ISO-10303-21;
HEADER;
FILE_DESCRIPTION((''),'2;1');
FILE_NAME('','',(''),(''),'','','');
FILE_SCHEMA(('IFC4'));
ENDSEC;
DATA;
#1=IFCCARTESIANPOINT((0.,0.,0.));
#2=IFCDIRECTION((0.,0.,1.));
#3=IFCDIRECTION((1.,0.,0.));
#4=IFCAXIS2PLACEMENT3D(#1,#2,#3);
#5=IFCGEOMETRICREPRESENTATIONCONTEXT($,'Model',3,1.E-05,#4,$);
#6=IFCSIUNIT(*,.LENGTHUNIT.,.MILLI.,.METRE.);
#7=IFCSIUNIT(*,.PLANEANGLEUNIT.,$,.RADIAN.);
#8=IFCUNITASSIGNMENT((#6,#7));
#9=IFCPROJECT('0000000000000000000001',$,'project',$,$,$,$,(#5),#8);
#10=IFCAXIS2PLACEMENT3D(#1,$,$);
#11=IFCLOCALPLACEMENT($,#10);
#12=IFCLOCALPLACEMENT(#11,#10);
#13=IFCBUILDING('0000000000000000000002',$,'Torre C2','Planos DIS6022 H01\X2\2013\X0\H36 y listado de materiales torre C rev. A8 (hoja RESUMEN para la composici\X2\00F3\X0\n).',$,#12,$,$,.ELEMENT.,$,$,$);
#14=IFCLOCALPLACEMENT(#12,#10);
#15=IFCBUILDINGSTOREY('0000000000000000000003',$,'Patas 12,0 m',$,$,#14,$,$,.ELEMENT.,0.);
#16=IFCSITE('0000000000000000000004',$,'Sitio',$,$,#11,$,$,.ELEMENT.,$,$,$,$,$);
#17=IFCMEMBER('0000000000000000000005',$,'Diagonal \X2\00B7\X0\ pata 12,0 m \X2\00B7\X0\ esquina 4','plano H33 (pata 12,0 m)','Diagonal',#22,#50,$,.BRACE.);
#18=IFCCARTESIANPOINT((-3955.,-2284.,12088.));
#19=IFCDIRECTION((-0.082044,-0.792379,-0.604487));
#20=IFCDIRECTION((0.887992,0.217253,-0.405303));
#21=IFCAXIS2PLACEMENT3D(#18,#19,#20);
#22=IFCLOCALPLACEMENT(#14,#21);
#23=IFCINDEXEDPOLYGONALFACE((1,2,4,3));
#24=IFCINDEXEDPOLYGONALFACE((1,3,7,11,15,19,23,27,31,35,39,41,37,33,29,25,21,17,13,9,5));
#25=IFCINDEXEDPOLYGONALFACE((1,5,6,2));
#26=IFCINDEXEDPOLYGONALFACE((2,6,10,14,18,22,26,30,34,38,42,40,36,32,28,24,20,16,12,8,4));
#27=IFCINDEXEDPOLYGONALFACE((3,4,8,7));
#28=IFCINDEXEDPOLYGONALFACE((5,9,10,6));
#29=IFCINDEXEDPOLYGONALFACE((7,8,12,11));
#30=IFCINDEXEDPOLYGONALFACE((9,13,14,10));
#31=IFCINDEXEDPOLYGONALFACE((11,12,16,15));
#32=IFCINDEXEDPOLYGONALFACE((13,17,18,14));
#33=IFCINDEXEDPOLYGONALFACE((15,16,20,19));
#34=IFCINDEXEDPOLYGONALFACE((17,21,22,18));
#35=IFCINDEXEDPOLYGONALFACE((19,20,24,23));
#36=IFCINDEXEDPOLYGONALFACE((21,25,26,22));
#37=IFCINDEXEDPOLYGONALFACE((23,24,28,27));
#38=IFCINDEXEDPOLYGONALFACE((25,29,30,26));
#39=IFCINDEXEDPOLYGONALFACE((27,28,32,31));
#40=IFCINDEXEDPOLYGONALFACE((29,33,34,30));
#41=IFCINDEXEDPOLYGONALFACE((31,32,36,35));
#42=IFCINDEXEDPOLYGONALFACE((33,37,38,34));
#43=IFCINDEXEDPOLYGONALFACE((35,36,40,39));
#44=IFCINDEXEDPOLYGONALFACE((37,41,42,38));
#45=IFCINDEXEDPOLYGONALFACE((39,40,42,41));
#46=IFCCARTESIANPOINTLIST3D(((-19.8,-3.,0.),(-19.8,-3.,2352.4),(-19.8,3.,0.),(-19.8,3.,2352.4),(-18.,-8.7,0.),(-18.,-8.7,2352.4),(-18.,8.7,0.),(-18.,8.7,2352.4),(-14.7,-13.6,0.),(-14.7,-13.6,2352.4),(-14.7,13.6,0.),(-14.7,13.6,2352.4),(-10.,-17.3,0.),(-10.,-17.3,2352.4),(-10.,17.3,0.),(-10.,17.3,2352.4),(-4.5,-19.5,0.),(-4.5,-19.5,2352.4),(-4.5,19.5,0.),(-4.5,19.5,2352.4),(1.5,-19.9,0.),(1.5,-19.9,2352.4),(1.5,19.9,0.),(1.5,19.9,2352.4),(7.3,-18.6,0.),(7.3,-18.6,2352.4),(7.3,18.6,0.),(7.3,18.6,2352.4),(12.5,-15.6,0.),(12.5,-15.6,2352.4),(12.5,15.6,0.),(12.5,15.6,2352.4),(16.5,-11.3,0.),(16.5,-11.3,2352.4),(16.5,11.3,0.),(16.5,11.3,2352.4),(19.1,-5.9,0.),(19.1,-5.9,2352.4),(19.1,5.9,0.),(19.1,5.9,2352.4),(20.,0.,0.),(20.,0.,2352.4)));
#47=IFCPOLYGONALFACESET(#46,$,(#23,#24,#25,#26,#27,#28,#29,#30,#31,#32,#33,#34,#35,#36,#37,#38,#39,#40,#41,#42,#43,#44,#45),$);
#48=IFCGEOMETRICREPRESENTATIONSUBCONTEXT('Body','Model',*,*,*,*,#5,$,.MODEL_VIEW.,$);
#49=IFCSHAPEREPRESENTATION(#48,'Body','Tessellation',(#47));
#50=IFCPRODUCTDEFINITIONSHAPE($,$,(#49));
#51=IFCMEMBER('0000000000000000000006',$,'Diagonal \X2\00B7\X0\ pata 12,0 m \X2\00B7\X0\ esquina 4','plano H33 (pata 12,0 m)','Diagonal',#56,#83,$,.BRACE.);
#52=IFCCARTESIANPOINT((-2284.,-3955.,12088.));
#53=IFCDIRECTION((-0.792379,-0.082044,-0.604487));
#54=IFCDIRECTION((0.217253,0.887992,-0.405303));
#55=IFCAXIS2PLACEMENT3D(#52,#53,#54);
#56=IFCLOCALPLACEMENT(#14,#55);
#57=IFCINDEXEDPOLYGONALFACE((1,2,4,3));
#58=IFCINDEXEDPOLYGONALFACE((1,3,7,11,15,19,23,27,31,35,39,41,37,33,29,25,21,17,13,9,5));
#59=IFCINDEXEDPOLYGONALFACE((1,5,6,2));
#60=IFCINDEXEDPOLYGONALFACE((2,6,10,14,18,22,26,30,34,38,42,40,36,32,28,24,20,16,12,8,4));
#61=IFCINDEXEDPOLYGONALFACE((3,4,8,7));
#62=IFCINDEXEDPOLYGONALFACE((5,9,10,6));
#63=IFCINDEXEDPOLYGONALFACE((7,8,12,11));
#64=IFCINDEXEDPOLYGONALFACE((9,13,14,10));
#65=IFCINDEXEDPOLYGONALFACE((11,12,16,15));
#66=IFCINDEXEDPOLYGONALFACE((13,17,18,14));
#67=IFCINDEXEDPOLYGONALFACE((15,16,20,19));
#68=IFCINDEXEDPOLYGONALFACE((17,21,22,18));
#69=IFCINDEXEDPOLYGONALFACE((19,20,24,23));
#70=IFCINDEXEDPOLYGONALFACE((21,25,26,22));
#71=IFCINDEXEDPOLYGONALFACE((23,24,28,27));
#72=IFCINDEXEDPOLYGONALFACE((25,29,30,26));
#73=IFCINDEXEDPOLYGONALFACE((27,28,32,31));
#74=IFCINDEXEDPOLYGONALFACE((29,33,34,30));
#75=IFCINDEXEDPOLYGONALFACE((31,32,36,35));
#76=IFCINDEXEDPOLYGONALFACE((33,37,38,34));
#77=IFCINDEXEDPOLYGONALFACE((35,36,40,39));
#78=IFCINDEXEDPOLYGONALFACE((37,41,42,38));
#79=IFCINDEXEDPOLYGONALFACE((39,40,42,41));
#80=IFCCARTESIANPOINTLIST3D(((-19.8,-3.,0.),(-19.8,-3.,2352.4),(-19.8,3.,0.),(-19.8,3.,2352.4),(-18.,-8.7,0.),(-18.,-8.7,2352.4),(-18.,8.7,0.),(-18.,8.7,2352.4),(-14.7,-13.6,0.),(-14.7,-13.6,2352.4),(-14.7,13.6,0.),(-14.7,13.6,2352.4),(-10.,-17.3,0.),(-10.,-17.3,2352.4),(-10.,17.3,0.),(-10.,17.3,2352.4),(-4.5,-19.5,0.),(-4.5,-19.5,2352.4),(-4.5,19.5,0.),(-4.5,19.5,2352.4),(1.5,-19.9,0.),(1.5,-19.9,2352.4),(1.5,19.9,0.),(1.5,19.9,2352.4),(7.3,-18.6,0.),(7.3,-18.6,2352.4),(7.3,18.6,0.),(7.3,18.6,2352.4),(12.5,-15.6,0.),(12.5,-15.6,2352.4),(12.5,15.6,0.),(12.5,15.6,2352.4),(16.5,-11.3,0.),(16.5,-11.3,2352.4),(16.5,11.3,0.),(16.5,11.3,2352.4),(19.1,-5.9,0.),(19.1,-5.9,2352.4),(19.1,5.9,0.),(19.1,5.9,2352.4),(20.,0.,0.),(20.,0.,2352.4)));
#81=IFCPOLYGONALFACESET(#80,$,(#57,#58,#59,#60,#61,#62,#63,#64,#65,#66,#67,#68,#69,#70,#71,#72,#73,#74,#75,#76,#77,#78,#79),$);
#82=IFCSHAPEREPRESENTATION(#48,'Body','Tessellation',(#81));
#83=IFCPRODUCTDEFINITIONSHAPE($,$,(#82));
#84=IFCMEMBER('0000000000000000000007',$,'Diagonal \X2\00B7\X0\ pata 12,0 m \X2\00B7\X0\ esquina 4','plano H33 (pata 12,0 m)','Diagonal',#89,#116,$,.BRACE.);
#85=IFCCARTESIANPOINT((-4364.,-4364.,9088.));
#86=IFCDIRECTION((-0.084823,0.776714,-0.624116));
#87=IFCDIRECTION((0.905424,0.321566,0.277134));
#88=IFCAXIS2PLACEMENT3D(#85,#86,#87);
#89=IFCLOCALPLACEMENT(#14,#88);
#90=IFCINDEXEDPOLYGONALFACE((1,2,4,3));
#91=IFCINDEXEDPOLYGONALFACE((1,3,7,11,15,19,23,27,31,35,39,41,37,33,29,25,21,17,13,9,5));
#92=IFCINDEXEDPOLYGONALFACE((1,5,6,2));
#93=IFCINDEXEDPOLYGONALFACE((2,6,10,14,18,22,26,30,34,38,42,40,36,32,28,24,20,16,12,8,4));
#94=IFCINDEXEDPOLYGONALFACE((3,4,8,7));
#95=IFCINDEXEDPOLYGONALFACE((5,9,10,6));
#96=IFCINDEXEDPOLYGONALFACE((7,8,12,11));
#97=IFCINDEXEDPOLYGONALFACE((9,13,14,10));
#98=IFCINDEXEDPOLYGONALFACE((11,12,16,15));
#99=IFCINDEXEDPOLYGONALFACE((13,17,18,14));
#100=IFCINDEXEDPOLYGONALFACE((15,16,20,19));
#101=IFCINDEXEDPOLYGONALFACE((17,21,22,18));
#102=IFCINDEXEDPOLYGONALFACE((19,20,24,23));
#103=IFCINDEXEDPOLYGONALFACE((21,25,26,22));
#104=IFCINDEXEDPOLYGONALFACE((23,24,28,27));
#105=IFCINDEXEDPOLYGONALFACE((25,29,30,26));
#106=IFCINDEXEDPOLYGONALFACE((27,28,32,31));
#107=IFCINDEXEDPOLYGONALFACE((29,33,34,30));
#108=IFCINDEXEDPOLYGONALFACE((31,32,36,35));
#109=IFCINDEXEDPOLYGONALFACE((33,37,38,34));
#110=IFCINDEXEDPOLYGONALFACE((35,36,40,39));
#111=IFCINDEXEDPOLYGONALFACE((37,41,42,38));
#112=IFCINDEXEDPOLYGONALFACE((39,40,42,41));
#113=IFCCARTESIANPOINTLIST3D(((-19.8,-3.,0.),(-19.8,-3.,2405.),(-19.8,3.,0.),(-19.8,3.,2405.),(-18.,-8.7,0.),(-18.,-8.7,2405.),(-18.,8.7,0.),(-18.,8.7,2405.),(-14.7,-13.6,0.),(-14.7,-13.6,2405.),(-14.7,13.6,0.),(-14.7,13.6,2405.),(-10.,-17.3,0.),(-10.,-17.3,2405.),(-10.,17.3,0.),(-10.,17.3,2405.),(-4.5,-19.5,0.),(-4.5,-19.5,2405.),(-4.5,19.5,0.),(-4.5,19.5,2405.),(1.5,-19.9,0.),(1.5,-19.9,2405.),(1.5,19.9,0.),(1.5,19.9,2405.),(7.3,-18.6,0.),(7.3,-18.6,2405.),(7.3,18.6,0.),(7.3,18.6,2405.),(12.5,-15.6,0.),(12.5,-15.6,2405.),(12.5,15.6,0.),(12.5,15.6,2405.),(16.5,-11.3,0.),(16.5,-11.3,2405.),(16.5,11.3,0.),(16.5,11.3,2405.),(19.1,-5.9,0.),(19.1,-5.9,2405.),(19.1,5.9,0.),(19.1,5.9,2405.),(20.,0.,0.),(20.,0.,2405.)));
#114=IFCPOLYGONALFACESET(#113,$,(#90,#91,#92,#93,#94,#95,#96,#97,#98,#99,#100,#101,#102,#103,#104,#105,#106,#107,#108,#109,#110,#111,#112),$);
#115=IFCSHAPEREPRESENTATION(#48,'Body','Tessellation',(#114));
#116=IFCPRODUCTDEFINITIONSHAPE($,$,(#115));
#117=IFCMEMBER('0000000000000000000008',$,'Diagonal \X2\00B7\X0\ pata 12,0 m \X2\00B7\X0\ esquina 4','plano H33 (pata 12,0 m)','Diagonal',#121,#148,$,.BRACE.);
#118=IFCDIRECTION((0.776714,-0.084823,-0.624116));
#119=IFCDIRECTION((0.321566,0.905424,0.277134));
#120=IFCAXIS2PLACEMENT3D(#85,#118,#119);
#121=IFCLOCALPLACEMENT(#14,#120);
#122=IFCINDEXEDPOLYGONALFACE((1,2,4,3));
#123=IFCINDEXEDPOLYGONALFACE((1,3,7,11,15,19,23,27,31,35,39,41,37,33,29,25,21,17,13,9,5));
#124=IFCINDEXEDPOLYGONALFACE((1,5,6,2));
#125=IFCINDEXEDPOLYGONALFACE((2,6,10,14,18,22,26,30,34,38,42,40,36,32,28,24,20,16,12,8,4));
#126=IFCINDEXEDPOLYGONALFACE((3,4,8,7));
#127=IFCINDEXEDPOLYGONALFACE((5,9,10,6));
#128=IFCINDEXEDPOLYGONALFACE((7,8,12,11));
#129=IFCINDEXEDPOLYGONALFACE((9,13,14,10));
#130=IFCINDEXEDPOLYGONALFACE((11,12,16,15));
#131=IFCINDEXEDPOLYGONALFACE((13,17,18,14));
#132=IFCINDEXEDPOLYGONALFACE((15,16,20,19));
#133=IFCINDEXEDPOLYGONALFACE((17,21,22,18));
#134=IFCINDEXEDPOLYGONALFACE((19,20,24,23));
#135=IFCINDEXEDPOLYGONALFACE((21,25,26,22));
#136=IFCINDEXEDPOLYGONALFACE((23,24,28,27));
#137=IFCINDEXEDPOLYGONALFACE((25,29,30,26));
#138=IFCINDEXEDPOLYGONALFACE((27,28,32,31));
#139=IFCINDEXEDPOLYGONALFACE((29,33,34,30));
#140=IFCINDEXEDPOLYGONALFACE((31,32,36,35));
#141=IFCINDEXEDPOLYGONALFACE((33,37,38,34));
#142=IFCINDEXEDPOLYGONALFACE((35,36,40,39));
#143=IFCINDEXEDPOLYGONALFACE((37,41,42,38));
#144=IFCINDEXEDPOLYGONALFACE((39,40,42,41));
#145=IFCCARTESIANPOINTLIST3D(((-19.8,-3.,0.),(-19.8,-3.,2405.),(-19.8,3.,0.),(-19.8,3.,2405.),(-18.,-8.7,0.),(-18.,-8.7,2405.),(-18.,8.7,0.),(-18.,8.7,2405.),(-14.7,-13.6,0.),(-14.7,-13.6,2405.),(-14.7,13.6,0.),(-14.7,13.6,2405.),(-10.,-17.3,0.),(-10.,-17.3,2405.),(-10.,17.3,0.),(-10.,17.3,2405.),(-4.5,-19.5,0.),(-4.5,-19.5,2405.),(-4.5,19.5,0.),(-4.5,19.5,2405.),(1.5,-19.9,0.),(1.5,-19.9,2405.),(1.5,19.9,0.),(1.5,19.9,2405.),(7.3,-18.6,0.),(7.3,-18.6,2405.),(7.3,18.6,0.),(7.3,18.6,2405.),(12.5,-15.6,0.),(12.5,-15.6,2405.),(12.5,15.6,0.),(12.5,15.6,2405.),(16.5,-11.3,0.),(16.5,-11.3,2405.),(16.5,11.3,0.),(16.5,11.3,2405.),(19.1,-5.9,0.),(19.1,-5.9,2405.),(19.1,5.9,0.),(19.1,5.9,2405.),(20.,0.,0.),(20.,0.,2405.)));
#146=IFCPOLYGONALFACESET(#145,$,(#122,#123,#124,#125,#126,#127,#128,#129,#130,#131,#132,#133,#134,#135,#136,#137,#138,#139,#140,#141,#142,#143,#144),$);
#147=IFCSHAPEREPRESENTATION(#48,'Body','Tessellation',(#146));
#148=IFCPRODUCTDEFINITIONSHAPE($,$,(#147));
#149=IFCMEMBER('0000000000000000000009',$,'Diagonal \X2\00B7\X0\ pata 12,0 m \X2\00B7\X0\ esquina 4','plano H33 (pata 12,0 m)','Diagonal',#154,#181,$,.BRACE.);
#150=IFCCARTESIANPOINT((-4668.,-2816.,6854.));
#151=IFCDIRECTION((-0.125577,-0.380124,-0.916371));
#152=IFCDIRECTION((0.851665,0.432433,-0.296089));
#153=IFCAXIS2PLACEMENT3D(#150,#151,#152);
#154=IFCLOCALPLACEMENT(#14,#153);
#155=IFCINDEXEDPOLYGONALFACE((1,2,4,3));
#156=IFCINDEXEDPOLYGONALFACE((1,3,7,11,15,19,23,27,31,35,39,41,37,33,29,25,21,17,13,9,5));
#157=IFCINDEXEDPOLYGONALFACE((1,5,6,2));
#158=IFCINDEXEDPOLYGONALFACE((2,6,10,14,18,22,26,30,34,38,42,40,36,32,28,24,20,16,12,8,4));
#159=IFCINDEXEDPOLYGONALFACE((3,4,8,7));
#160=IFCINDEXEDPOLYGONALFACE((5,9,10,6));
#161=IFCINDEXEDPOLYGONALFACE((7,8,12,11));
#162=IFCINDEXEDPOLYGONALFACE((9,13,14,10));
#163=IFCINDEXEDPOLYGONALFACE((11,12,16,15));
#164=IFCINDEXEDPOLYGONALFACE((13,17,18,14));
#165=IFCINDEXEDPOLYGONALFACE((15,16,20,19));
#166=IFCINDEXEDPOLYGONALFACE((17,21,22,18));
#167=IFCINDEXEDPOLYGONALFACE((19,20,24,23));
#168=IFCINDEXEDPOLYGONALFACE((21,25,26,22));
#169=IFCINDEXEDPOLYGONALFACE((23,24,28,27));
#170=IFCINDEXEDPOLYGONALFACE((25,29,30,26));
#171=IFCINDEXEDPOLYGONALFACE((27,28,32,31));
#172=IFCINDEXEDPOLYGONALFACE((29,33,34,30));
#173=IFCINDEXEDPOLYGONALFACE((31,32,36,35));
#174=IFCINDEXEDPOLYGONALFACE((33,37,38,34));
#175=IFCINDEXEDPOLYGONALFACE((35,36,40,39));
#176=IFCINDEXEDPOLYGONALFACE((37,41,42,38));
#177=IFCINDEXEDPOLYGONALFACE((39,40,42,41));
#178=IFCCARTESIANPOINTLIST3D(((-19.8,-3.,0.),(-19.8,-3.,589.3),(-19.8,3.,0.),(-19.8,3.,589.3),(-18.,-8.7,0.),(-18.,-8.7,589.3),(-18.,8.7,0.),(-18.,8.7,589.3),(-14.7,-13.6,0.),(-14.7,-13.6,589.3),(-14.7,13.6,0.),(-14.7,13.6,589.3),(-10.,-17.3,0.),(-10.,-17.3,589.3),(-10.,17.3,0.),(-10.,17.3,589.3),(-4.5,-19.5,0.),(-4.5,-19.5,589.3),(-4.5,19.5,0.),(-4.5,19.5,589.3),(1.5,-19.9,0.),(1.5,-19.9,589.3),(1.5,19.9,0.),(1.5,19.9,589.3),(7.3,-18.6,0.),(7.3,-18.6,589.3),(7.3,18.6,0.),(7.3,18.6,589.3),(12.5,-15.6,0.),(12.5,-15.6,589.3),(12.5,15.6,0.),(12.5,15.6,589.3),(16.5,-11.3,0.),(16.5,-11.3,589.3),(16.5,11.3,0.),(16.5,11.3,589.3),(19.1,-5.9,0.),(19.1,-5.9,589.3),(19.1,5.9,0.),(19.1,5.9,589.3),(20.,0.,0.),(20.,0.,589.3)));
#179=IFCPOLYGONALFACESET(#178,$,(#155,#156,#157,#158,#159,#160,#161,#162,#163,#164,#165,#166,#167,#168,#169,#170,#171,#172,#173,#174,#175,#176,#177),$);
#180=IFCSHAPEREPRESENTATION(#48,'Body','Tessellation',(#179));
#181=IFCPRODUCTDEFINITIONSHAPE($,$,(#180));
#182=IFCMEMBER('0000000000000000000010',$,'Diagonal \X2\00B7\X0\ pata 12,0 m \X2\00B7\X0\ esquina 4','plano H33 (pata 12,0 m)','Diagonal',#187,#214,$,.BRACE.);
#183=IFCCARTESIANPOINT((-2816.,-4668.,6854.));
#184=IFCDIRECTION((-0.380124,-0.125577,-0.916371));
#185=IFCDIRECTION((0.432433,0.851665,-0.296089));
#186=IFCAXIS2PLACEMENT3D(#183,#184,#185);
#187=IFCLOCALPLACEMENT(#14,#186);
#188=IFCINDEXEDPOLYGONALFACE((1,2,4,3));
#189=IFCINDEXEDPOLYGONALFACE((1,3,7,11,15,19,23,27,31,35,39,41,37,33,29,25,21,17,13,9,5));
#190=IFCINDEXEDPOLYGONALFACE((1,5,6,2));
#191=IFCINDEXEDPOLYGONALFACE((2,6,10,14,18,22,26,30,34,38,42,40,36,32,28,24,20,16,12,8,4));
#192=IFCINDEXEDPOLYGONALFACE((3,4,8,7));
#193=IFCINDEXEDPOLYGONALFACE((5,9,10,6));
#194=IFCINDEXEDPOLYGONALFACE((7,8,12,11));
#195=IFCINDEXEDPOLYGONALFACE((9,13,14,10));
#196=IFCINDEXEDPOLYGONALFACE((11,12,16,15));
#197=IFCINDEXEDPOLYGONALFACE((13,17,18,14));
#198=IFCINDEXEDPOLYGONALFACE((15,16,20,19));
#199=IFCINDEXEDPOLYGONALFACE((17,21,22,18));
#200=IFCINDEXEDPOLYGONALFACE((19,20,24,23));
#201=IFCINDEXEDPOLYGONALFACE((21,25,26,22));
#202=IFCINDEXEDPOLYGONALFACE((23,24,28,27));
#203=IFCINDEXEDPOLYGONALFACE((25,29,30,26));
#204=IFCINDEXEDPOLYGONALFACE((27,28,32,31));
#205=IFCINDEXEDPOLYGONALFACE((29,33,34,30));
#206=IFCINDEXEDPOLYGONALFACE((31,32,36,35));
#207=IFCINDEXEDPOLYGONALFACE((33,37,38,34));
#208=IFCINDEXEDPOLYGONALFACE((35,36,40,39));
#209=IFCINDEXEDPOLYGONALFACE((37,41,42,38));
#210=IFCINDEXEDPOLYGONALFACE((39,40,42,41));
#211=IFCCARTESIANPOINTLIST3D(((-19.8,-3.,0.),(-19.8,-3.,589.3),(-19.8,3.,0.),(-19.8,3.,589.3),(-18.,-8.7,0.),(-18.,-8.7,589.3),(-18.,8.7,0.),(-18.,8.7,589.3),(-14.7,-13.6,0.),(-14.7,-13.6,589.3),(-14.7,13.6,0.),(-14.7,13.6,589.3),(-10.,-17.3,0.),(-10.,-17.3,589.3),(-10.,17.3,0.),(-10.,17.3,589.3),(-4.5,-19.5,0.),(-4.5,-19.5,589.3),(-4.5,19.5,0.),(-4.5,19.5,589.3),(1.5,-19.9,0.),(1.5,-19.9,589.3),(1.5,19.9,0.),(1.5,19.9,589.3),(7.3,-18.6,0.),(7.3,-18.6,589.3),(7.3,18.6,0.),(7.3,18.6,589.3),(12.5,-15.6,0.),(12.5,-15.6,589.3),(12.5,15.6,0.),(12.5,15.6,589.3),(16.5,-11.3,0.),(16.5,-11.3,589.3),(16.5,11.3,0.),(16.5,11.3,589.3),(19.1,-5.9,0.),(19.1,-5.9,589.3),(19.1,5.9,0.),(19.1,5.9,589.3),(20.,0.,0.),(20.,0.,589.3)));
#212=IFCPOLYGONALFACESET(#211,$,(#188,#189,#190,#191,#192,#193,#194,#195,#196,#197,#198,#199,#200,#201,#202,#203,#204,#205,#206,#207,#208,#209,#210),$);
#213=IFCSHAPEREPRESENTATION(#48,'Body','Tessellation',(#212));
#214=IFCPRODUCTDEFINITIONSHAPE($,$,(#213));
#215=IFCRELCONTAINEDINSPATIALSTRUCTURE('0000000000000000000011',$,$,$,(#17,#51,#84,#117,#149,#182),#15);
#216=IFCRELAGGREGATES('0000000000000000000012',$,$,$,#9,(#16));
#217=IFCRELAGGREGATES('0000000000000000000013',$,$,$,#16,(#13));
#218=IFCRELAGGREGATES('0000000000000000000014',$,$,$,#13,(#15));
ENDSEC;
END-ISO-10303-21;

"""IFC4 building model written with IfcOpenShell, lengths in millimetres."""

from ifc_helpers import new_model, si_unit, frame, origin, origin_with_axes, place, context, subcontext, project, spatial, circle, extrude, element, save


model = new_model("IFC4")

# Units and contexts
model_context = context("Model", 3, precision=1e-05, world=origin_with_axes())
body_context = subcontext(model_context, "Body", "Model", "MODEL_VIEW")
ifc_project = project(units=[si_unit("LENGTHUNIT", "METRE", prefix="MILLI"), si_unit("PLANEANGLEUNIT", "RADIAN")], contexts=[model_context])

# Site, building, storey
site_placement = place(None, origin())
site = spatial("IfcSite", under=ifc_project, at=site_placement, Name="Sitio", CompositionType="ELEMENT")
building_placement = place(site_placement, origin())
building = spatial("IfcBuilding", under=site, at=building_placement, Name="Torre C2", Description="Planos DIS6022 H01–H36 y listado de materiales torre C rev. A8 (hoja RESUMEN para la composición).", CompositionType="ELEMENT")
storey_placement = place(building_placement, origin())
storey = spatial("IfcBuildingStorey", under=building, at=storey_placement, Name="Patas 12,0 m", CompositionType="ELEMENT", Elevation=0.0)

# Members
for number, where, z_axis, x_axis, name in (
    (1, (-3955.0, -2284.0, 12088.0), (-0.082044, -0.792379, -0.604487), (0.887992, 0.217253, -0.405303), "Diagonal · pata 12,0 m · esquina 4"),
    (2, (-2284.0, -3955.0, 12088.0), (-0.792379, -0.082044, -0.604487), (0.217253, 0.887992, -0.405303), "Diagonal · pata 12,0 m · esquina 4"),
):
    element("IfcMember", number, at=place(storey_placement, frame(where, z_axis=z_axis, x_axis=x_axis)), inside=storey, Name=name, Description="plano H33 (pata 12,0 m)", ObjectType="Diagonal", PredefinedType="BRACE", context=body_context, shape_type="SweptSolid", body=[
        extrude(circle(Radius=20.0), None, (0.0, 0.0, 1.0), 2352.4),
    ])
for number, where, z_axis, x_axis, name in (
    (3, (-4364.0, -4364.0, 9088.0), (-0.084823, 0.776714, -0.624116), (0.905424, 0.321566, 0.277134), "Diagonal · pata 12,0 m · esquina 4"),
    (4, (-4364.0, -4364.0, 9088.0), (0.776714, -0.084823, -0.624116), (0.321566, 0.905424, 0.277134), "Diagonal · pata 12,0 m · esquina 4"),
):
    element("IfcMember", number, at=place(storey_placement, frame(where, z_axis=z_axis, x_axis=x_axis)), inside=storey, Name=name, Description="plano H33 (pata 12,0 m)", ObjectType="Diagonal", PredefinedType="BRACE", context=body_context, shape_type="SweptSolid", body=[
        extrude(circle(Radius=20.0), None, (0.0, 0.0, 1.0), 2405.0),
    ])
for number, where, z_axis, x_axis, name in (
    (5, (-4668.0, -2816.0, 6854.0), (-0.125577, -0.380124, -0.916371), (0.851665, 0.432433, -0.296089), "Diagonal · pata 12,0 m · esquina 4"),
    (6, (-2816.0, -4668.0, 6854.0), (-0.380124, -0.125577, -0.916371), (0.432433, 0.851665, -0.296089), "Diagonal · pata 12,0 m · esquina 4"),
):
    element("IfcMember", number, at=place(storey_placement, frame(where, z_axis=z_axis, x_axis=x_axis)), inside=storey, Name=name, Description="plano H33 (pata 12,0 m)", ObjectType="Diagonal", PredefinedType="BRACE", context=body_context, shape_type="SweptSolid", body=[
        extrude(circle(Radius=20.0), None, (0.0, 0.0, 1.0), 589.3),
    ])

save(model, "model.ifc")
